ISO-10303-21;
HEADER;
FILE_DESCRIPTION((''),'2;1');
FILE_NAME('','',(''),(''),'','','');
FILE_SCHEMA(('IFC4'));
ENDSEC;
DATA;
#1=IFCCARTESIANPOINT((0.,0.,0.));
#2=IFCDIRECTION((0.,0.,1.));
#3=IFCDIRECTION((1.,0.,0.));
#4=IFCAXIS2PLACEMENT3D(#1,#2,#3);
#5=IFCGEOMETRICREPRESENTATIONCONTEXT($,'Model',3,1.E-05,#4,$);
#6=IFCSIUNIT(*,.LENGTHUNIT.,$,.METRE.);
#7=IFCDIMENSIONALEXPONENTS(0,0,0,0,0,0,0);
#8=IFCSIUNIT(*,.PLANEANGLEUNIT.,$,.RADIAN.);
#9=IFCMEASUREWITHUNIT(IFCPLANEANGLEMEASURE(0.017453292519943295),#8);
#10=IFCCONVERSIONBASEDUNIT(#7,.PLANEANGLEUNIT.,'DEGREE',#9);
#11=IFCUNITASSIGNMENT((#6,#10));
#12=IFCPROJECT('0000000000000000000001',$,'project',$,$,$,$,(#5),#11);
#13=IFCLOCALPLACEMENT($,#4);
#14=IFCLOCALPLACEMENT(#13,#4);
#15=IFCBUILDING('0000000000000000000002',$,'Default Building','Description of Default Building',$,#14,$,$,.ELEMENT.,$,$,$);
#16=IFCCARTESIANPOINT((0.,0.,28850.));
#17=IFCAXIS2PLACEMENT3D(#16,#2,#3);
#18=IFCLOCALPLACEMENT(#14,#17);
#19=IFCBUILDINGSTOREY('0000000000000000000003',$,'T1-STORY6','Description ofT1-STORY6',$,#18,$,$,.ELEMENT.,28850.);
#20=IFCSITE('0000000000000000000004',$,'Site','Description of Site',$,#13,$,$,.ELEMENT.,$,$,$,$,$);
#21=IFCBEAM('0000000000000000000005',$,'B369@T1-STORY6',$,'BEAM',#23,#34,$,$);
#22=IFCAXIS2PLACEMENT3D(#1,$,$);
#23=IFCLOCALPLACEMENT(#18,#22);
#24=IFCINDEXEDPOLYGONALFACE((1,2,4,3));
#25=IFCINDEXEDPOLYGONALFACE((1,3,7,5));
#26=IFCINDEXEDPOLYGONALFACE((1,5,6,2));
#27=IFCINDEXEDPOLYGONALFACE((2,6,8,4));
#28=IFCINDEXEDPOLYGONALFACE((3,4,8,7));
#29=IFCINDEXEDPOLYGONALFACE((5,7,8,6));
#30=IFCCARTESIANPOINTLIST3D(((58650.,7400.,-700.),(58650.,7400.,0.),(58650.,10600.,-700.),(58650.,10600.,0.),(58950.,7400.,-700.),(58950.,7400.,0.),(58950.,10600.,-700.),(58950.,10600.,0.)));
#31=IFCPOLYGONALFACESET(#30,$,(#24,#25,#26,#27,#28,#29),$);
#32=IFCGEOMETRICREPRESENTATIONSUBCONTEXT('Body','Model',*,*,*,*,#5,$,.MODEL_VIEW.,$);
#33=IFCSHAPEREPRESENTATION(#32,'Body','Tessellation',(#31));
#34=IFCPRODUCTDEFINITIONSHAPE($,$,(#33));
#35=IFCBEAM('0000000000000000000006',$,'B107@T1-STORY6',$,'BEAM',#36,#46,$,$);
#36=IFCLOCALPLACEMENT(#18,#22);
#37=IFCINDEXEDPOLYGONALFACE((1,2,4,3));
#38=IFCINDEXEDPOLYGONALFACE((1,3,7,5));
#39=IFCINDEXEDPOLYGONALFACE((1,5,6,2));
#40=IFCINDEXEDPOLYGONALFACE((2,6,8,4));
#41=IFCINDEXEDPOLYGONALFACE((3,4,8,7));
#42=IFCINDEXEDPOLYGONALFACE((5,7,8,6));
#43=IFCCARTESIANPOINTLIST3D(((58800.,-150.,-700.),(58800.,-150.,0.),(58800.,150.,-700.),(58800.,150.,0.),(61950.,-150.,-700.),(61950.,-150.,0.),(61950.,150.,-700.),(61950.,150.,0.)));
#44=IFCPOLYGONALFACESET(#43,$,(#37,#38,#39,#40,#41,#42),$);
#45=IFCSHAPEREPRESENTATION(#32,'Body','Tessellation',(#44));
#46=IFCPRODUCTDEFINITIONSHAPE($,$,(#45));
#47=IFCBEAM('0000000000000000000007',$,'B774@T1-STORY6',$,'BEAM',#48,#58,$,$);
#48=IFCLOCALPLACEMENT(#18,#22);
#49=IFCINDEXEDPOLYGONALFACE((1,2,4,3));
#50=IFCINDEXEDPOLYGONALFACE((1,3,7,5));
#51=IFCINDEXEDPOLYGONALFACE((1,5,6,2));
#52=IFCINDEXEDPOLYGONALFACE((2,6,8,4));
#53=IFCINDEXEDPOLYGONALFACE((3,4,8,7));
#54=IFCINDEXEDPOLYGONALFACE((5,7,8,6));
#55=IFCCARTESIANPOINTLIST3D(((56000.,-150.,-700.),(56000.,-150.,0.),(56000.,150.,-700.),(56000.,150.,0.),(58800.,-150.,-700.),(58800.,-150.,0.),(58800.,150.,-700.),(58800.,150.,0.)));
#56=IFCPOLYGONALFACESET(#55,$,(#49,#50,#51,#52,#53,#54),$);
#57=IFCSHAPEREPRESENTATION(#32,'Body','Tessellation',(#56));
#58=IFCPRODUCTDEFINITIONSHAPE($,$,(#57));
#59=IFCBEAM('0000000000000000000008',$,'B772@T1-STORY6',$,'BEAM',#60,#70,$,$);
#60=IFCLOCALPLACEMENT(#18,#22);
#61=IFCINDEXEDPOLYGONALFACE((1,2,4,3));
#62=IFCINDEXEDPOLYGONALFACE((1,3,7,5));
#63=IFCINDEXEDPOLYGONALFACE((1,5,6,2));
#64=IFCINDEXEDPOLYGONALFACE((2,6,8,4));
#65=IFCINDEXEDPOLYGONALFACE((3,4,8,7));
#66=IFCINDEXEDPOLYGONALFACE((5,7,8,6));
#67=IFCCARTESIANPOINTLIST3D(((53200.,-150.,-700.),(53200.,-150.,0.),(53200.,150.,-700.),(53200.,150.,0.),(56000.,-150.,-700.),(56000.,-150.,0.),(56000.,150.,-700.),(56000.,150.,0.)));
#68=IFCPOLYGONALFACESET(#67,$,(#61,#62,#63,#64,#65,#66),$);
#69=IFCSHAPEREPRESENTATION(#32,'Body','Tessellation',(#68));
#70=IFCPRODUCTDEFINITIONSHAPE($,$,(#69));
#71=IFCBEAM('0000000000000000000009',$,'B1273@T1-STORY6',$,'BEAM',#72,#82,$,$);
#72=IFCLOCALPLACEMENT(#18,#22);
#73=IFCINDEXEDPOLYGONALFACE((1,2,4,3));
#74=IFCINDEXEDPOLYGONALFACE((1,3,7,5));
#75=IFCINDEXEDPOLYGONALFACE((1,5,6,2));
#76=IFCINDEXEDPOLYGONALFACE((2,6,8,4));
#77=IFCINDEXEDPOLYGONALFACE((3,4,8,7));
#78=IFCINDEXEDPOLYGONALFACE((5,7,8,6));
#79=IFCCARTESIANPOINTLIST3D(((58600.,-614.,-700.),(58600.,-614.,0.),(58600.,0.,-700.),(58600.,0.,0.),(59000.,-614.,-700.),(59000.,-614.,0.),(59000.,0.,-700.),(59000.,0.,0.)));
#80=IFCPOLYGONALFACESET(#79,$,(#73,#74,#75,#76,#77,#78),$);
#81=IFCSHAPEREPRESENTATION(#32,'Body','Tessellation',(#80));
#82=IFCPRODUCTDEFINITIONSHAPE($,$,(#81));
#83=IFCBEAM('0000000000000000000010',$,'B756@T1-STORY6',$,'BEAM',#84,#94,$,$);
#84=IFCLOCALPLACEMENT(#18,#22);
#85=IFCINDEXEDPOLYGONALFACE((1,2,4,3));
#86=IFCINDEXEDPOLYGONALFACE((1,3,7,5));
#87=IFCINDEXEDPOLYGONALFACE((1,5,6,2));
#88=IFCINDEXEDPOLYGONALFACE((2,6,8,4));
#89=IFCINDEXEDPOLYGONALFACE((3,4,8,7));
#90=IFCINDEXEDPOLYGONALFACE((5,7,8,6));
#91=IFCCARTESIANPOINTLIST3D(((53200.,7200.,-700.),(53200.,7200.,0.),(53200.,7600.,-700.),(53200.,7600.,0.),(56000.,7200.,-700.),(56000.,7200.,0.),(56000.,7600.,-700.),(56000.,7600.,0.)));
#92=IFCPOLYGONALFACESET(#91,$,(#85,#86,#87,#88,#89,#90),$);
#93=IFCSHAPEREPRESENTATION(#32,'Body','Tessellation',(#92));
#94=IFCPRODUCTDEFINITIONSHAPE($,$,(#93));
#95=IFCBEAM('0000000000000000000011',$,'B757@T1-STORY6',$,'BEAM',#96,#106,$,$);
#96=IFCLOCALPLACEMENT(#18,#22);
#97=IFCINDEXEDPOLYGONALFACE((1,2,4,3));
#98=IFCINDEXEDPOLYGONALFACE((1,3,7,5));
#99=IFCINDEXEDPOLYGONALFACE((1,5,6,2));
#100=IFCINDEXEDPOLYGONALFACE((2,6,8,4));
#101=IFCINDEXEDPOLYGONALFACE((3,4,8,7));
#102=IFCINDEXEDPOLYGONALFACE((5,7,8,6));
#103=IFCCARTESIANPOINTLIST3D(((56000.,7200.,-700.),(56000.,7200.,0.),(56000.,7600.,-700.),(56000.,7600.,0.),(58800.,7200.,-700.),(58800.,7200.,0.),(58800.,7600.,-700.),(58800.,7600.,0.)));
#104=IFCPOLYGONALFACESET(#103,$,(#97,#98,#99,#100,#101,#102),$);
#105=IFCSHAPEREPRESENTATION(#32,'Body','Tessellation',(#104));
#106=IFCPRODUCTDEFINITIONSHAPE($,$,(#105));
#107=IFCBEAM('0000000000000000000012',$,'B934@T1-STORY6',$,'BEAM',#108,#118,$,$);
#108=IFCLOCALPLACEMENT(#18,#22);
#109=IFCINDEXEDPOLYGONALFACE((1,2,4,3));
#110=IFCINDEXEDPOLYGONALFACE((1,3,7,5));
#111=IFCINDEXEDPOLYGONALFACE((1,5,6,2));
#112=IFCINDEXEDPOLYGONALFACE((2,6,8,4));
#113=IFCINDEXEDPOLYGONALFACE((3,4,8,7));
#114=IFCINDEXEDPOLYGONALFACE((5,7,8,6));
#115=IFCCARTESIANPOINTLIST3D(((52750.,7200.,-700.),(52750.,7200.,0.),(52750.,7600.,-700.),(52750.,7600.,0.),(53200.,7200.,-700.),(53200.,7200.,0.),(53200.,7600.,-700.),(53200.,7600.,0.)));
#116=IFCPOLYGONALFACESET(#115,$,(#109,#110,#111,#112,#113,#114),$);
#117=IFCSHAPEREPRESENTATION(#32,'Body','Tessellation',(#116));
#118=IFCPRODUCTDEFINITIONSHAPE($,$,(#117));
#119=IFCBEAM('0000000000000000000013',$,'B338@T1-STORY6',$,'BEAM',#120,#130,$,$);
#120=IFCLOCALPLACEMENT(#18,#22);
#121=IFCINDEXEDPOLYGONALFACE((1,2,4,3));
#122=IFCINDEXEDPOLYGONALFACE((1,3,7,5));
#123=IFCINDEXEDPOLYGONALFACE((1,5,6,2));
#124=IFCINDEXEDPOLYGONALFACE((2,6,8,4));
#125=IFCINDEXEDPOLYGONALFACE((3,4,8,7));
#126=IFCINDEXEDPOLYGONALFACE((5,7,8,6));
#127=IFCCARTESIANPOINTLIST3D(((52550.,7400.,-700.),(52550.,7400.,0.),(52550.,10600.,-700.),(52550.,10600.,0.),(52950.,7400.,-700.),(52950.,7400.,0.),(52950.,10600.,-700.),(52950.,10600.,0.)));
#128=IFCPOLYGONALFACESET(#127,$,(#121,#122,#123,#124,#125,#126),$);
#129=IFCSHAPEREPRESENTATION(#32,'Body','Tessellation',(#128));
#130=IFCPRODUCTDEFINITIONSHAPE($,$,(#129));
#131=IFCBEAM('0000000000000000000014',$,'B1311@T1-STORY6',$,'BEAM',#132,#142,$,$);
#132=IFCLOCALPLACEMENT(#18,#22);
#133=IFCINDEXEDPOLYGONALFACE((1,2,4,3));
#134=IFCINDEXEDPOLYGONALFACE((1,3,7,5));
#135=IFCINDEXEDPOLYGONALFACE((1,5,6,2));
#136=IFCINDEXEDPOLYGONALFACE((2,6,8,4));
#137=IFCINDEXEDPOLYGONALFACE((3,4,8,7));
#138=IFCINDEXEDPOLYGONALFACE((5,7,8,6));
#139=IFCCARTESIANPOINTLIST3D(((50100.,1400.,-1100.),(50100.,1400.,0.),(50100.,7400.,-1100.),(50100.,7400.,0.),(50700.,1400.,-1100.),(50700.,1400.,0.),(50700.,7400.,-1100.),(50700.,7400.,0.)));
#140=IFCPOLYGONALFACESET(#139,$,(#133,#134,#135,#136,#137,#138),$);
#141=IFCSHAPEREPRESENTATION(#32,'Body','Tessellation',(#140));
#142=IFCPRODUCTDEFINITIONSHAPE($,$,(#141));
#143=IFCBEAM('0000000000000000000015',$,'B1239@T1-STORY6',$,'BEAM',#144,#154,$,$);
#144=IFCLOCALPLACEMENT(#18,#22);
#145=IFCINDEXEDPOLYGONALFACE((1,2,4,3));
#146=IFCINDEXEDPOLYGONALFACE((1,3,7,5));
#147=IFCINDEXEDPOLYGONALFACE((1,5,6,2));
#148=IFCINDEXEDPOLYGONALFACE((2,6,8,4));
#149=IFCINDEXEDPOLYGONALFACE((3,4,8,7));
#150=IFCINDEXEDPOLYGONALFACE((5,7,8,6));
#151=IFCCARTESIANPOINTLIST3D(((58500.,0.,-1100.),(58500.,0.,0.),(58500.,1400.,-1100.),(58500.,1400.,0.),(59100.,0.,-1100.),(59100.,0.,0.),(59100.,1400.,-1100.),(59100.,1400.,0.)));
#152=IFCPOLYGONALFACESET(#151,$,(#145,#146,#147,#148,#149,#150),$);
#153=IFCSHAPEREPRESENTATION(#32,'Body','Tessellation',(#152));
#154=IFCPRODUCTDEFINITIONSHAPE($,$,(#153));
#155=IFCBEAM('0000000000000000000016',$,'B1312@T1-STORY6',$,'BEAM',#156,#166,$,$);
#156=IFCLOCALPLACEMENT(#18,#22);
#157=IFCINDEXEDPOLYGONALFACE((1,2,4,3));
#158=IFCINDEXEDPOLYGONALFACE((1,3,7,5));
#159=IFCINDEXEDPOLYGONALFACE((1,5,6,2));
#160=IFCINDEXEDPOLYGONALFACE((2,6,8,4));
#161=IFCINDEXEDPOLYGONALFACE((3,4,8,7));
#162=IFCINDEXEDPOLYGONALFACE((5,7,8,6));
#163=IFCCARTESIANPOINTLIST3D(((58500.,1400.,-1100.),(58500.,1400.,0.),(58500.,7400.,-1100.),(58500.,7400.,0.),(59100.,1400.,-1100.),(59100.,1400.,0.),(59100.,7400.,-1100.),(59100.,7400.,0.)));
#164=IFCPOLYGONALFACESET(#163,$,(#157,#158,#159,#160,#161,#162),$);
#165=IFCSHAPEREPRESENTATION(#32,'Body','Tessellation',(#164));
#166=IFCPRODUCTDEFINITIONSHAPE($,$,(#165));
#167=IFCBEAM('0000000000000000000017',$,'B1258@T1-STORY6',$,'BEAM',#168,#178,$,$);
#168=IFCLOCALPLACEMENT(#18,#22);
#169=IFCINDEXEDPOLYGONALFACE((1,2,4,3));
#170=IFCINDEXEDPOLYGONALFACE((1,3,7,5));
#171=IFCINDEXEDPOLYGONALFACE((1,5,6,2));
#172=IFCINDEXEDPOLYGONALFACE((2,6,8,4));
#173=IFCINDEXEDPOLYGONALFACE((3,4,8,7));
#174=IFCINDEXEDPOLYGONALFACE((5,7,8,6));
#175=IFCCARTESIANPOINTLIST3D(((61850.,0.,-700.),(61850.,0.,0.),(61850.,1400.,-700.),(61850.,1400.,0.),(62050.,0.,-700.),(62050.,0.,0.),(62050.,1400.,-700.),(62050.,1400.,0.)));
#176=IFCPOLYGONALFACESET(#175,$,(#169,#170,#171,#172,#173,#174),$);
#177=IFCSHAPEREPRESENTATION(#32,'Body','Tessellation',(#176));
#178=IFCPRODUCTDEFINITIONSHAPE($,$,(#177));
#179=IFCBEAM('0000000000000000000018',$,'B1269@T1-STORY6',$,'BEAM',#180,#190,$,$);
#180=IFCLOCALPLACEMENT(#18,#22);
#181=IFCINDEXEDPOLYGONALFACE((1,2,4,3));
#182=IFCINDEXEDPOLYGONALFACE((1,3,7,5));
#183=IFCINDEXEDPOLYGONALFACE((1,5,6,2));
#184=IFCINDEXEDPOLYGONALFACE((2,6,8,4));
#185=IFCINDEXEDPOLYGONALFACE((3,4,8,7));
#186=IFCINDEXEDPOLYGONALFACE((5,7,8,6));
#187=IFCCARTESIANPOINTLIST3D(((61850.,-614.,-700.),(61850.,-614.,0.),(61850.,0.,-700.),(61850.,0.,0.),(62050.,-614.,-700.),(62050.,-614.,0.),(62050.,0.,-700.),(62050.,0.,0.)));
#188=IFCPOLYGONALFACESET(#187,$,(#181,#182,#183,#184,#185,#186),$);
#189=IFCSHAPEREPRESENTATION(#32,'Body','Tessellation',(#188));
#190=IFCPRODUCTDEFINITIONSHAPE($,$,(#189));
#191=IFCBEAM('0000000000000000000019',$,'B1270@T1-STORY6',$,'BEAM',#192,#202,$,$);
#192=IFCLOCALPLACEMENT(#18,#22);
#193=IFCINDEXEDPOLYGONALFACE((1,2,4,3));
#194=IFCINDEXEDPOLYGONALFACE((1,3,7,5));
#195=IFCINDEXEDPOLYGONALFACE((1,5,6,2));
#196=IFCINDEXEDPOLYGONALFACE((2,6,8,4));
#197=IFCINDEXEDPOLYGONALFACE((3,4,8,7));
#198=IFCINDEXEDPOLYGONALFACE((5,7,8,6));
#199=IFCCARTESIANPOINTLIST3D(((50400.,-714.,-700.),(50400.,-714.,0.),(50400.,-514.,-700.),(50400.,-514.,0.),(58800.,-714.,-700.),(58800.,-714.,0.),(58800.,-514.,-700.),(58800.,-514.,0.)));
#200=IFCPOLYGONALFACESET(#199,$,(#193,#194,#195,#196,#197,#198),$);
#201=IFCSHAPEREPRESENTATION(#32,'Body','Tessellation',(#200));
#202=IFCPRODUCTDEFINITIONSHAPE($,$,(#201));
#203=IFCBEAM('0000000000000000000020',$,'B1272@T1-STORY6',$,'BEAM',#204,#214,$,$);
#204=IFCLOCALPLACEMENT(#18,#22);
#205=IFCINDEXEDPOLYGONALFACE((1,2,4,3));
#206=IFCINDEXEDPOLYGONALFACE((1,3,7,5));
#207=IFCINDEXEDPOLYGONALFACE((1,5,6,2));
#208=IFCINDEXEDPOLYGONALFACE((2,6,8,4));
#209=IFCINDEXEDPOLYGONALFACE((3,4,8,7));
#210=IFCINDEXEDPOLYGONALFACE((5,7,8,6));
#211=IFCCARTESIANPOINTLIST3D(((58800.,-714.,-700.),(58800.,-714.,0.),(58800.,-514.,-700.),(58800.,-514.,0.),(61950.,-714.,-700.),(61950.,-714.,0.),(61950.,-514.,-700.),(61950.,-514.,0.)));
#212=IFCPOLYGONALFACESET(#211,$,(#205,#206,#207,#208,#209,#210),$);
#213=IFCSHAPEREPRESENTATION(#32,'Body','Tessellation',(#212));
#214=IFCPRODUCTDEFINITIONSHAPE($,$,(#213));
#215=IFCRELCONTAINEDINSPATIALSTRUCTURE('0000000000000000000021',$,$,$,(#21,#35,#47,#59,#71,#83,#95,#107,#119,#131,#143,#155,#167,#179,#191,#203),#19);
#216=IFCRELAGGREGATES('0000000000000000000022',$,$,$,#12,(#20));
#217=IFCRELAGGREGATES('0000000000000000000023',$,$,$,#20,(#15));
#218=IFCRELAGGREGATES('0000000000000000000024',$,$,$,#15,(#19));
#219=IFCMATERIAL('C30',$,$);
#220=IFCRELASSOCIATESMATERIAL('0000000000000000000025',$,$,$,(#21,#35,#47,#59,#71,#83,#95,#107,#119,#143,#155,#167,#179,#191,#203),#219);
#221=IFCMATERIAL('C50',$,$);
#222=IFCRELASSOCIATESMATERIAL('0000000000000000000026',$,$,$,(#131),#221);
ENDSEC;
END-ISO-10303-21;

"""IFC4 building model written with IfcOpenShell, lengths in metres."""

from ifc_helpers import new_model, entity, si_unit, converted_unit, frame, origin_with_axes, place, context, subcontext, project, spatial, rectangle, extrude, material, element, save


model = new_model("IFC4")

# Units and contexts
model_context = context("Model", 3, precision=1e-05, world=origin_with_axes())
body_context = subcontext(model_context, "Body", "Model", "MODEL_VIEW")
ifc_project = project(units=[si_unit("LENGTHUNIT", "METRE"), converted_unit("PLANEANGLEUNIT", "DEGREE", entity("IfcPlaneAngleMeasure", 0.017453292519943295), si_unit("PLANEANGLEUNIT", "RADIAN"), dimensions=[0, 0, 0, 0, 0, 0, 0])], contexts=[model_context])

# Site, building, storey
site_placement = place(None, origin_with_axes())
site = spatial("IfcSite", under=ifc_project, at=site_placement, Name="Site", Description="Description of Site", CompositionType="ELEMENT")
building_placement = place(site_placement, origin_with_axes())
building = spatial("IfcBuilding", under=site, at=building_placement, Name="Default Building", Description="Description of Default Building", CompositionType="ELEMENT")
storey_placement = place(building_placement, frame((0.0, 0.0, 28850.0), z_axis=(0.0, 0.0, 1.0), x_axis=(1.0, 0.0, 0.0)))
storey = spatial("IfcBuildingStorey", under=building, at=storey_placement, Name="T1-STORY6", Description="Description ofT1-STORY6", CompositionType="ELEMENT", Elevation=28850.0)

# Beams
ifc_material_1 = material(Name="C30")
beam_1_placement = place(storey_placement, frame((58800.0, 7400.0, -350.0), z_axis=(0.0, 1.0, 0.0), x_axis=(-1.0, 0.0, 0.0)))
element("IfcBeam", 1, at=beam_1_placement, inside=storey, material=ifc_material_1, Name="B369@T1-STORY6", ObjectType="BEAM", context=body_context, shape_type="SweptSolid", body=[
    extrude(rectangle(XDim=300.0, YDim=700.0), origin_with_axes(), (0.0, 0.0, 1.0), 3200.0),
])
beam_2_placement = place(storey_placement, frame((58800.0, 0.0, -350.0), z_axis=(1.0, 0.0, 0.0), x_axis=(0.0, 1.0, 0.0)))
element("IfcBeam", 2, at=beam_2_placement, inside=storey, material=ifc_material_1, Name="B107@T1-STORY6", ObjectType="BEAM", context=body_context, shape_type="SweptSolid", body=[
    extrude(rectangle(XDim=300.0, YDim=700.0), origin_with_axes(), (0.0, 0.0, 1.0), 3150.0),
])
for number, where, z_axis, x_axis, name in (
    (3, (56000.0, 0.0, -350.0), (1.0, 0.0, 0.0), (0.0, 1.0, 0.0), "B774@T1-STORY6"),
    (4, (53200.0, 0.0, -350.0), (1.0, 0.0, 0.0), (0.0, 1.0, 0.0), "B772@T1-STORY6"),
):
    element("IfcBeam", number, at=place(storey_placement, frame(where, z_axis=z_axis, x_axis=x_axis)), inside=storey, material=ifc_material_1, Name=name, ObjectType="BEAM", context=body_context, shape_type="SweptSolid", body=[
        extrude(rectangle(XDim=300.0, YDim=700.0), origin_with_axes(), (0.0, 0.0, 1.0), 2800.0),
    ])
beam_3_placement = place(storey_placement, frame((58800.0, -614.0, -350.0), z_axis=(0.0, 1.0, 0.0), x_axis=(-1.0, 0.0, 0.0)))
element("IfcBeam", 5, at=beam_3_placement, inside=storey, material=ifc_material_1, Name="B1273@T1-STORY6", ObjectType="BEAM", context=body_context, shape_type="SweptSolid", body=[
    extrude(rectangle(XDim=400.0, YDim=700.0), origin_with_axes(), (0.0, 0.0, 1.0), 614.0),
])
for number, where, z_axis, x_axis, name in (
    (6, (53200.0, 7400.0, -350.0), (1.0, 0.0, 0.0), (0.0, 1.0, 0.0), "B756@T1-STORY6"),
    (7, (56000.0, 7400.0, -350.0), (1.0, 0.0, 0.0), (0.0, 1.0, 0.0), "B757@T1-STORY6"),
):
    element("IfcBeam", number, at=place(storey_placement, frame(where, z_axis=z_axis, x_axis=x_axis)), inside=storey, material=ifc_material_1, Name=name, ObjectType="BEAM", context=body_context, shape_type="SweptSolid", body=[
        extrude(rectangle(XDim=400.0, YDim=700.0), origin_with_axes(), (0.0, 0.0, 1.0), 2800.0),
    ])
beam_4_placement = place(storey_placement, frame((52750.0, 7400.0, -350.0), z_axis=(1.0, 0.0, 0.0), x_axis=(0.0, 1.0, 0.0)))
element("IfcBeam", 8, at=beam_4_placement, inside=storey, material=ifc_material_1, Name="B934@T1-STORY6", ObjectType="BEAM", context=body_context, shape_type="SweptSolid", body=[
    extrude(rectangle(XDim=400.0, YDim=700.0), origin_with_axes(), (0.0, 0.0, 1.0), 450.0),
])
beam_5_placement = place(storey_placement, frame((52750.0, 7400.0, -350.0), z_axis=(0.0, 1.0, 0.0), x_axis=(-1.0, 0.0, 0.0)))
element("IfcBeam", 9, at=beam_5_placement, inside=storey, material=ifc_material_1, Name="B338@T1-STORY6", ObjectType="BEAM", context=body_context, shape_type="SweptSolid", body=[
    extrude(rectangle(XDim=400.0, YDim=700.0), origin_with_axes(), (0.0, 0.0, 1.0), 3200.0),
])
ifc_material_2 = material(Name="C50")
beam_6_placement = place(storey_placement, frame((50400.0, 1400.0, -550.0), z_axis=(0.0, 1.0, 0.0), x_axis=(-1.0, 0.0, 0.0)))
element("IfcBeam", 10, at=beam_6_placement, inside=storey, material=ifc_material_2, Name="B1311@T1-STORY6", ObjectType="BEAM", context=body_context, shape_type="SweptSolid", body=[
    extrude(rectangle(XDim=600.0, YDim=1100.0), origin_with_axes(), (0.0, 0.0, 1.0), 6000.0),
])
beam_7_placement = place(storey_placement, frame((58800.0, 0.0, -550.0), z_axis=(0.0, 1.0, 0.0), x_axis=(-1.0, 0.0, 0.0)))
element("IfcBeam", 11, at=beam_7_placement, inside=storey, material=ifc_material_1, Name="B1239@T1-STORY6", ObjectType="BEAM", context=body_context, shape_type="SweptSolid", body=[
    extrude(rectangle(XDim=600.0, YDim=1100.0), origin_with_axes(), (0.0, 0.0, 1.0), 1400.0),
])
beam_8_placement = place(storey_placement, frame((58800.0, 1400.0, -550.0), z_axis=(0.0, 1.0, 0.0), x_axis=(-1.0, 0.0, 0.0)))
element("IfcBeam", 12, at=beam_8_placement, inside=storey, material=ifc_material_1, Name="B1312@T1-STORY6", ObjectType="BEAM", context=body_context, shape_type="SweptSolid", body=[
    extrude(rectangle(XDim=600.0, YDim=1100.0), origin_with_axes(), (0.0, 0.0, 1.0), 6000.0),
])
beam_9_placement = place(storey_placement, frame((61950.0, 0.0, -350.0), z_axis=(0.0, 1.0, 0.0), x_axis=(-1.0, 0.0, 0.0)))
element("IfcBeam", 13, at=beam_9_placement, inside=storey, material=ifc_material_1, Name="B1258@T1-STORY6", ObjectType="BEAM", context=body_context, shape_type="SweptSolid", body=[
    extrude(rectangle(XDim=200.0, YDim=700.0), origin_with_axes(), (0.0, 0.0, 1.0), 1400.0),
])
beam_10_placement = place(storey_placement, frame((61950.0, -614.0, -350.0), z_axis=(0.0, 1.0, 0.0), x_axis=(-1.0, 0.0, 0.0)))
element("IfcBeam", 14, at=beam_10_placement, inside=storey, material=ifc_material_1, Name="B1269@T1-STORY6", ObjectType="BEAM", context=body_context, shape_type="SweptSolid", body=[
    extrude(rectangle(XDim=200.0, YDim=700.0), origin_with_axes(), (0.0, 0.0, 1.0), 614.0),
])
beam_11_placement = place(storey_placement, frame((50400.0, -614.0, -350.0), z_axis=(1.0, 0.0, 0.0), x_axis=(0.0, 1.0, 0.0)))
element("IfcBeam", 15, at=beam_11_placement, inside=storey, material=ifc_material_1, Name="B1270@T1-STORY6", ObjectType="BEAM", context=body_context, shape_type="SweptSolid", body=[
    extrude(rectangle(XDim=200.0, YDim=700.0), origin_with_axes(), (0.0, 0.0, 1.0), 8400.0),
])
beam_12_placement = place(storey_placement, frame((58800.0, -614.0, -350.0), z_axis=(1.0, 0.0, 0.0), x_axis=(0.0, 1.0, 0.0)))
element("IfcBeam", 16, at=beam_12_placement, inside=storey, material=ifc_material_1, Name="B1272@T1-STORY6", ObjectType="BEAM", context=body_context, shape_type="SweptSolid", body=[
    extrude(rectangle(XDim=200.0, YDim=700.0), origin_with_axes(), (0.0, 0.0, 1.0), 3150.0),
])

save(model, "model.ifc")
